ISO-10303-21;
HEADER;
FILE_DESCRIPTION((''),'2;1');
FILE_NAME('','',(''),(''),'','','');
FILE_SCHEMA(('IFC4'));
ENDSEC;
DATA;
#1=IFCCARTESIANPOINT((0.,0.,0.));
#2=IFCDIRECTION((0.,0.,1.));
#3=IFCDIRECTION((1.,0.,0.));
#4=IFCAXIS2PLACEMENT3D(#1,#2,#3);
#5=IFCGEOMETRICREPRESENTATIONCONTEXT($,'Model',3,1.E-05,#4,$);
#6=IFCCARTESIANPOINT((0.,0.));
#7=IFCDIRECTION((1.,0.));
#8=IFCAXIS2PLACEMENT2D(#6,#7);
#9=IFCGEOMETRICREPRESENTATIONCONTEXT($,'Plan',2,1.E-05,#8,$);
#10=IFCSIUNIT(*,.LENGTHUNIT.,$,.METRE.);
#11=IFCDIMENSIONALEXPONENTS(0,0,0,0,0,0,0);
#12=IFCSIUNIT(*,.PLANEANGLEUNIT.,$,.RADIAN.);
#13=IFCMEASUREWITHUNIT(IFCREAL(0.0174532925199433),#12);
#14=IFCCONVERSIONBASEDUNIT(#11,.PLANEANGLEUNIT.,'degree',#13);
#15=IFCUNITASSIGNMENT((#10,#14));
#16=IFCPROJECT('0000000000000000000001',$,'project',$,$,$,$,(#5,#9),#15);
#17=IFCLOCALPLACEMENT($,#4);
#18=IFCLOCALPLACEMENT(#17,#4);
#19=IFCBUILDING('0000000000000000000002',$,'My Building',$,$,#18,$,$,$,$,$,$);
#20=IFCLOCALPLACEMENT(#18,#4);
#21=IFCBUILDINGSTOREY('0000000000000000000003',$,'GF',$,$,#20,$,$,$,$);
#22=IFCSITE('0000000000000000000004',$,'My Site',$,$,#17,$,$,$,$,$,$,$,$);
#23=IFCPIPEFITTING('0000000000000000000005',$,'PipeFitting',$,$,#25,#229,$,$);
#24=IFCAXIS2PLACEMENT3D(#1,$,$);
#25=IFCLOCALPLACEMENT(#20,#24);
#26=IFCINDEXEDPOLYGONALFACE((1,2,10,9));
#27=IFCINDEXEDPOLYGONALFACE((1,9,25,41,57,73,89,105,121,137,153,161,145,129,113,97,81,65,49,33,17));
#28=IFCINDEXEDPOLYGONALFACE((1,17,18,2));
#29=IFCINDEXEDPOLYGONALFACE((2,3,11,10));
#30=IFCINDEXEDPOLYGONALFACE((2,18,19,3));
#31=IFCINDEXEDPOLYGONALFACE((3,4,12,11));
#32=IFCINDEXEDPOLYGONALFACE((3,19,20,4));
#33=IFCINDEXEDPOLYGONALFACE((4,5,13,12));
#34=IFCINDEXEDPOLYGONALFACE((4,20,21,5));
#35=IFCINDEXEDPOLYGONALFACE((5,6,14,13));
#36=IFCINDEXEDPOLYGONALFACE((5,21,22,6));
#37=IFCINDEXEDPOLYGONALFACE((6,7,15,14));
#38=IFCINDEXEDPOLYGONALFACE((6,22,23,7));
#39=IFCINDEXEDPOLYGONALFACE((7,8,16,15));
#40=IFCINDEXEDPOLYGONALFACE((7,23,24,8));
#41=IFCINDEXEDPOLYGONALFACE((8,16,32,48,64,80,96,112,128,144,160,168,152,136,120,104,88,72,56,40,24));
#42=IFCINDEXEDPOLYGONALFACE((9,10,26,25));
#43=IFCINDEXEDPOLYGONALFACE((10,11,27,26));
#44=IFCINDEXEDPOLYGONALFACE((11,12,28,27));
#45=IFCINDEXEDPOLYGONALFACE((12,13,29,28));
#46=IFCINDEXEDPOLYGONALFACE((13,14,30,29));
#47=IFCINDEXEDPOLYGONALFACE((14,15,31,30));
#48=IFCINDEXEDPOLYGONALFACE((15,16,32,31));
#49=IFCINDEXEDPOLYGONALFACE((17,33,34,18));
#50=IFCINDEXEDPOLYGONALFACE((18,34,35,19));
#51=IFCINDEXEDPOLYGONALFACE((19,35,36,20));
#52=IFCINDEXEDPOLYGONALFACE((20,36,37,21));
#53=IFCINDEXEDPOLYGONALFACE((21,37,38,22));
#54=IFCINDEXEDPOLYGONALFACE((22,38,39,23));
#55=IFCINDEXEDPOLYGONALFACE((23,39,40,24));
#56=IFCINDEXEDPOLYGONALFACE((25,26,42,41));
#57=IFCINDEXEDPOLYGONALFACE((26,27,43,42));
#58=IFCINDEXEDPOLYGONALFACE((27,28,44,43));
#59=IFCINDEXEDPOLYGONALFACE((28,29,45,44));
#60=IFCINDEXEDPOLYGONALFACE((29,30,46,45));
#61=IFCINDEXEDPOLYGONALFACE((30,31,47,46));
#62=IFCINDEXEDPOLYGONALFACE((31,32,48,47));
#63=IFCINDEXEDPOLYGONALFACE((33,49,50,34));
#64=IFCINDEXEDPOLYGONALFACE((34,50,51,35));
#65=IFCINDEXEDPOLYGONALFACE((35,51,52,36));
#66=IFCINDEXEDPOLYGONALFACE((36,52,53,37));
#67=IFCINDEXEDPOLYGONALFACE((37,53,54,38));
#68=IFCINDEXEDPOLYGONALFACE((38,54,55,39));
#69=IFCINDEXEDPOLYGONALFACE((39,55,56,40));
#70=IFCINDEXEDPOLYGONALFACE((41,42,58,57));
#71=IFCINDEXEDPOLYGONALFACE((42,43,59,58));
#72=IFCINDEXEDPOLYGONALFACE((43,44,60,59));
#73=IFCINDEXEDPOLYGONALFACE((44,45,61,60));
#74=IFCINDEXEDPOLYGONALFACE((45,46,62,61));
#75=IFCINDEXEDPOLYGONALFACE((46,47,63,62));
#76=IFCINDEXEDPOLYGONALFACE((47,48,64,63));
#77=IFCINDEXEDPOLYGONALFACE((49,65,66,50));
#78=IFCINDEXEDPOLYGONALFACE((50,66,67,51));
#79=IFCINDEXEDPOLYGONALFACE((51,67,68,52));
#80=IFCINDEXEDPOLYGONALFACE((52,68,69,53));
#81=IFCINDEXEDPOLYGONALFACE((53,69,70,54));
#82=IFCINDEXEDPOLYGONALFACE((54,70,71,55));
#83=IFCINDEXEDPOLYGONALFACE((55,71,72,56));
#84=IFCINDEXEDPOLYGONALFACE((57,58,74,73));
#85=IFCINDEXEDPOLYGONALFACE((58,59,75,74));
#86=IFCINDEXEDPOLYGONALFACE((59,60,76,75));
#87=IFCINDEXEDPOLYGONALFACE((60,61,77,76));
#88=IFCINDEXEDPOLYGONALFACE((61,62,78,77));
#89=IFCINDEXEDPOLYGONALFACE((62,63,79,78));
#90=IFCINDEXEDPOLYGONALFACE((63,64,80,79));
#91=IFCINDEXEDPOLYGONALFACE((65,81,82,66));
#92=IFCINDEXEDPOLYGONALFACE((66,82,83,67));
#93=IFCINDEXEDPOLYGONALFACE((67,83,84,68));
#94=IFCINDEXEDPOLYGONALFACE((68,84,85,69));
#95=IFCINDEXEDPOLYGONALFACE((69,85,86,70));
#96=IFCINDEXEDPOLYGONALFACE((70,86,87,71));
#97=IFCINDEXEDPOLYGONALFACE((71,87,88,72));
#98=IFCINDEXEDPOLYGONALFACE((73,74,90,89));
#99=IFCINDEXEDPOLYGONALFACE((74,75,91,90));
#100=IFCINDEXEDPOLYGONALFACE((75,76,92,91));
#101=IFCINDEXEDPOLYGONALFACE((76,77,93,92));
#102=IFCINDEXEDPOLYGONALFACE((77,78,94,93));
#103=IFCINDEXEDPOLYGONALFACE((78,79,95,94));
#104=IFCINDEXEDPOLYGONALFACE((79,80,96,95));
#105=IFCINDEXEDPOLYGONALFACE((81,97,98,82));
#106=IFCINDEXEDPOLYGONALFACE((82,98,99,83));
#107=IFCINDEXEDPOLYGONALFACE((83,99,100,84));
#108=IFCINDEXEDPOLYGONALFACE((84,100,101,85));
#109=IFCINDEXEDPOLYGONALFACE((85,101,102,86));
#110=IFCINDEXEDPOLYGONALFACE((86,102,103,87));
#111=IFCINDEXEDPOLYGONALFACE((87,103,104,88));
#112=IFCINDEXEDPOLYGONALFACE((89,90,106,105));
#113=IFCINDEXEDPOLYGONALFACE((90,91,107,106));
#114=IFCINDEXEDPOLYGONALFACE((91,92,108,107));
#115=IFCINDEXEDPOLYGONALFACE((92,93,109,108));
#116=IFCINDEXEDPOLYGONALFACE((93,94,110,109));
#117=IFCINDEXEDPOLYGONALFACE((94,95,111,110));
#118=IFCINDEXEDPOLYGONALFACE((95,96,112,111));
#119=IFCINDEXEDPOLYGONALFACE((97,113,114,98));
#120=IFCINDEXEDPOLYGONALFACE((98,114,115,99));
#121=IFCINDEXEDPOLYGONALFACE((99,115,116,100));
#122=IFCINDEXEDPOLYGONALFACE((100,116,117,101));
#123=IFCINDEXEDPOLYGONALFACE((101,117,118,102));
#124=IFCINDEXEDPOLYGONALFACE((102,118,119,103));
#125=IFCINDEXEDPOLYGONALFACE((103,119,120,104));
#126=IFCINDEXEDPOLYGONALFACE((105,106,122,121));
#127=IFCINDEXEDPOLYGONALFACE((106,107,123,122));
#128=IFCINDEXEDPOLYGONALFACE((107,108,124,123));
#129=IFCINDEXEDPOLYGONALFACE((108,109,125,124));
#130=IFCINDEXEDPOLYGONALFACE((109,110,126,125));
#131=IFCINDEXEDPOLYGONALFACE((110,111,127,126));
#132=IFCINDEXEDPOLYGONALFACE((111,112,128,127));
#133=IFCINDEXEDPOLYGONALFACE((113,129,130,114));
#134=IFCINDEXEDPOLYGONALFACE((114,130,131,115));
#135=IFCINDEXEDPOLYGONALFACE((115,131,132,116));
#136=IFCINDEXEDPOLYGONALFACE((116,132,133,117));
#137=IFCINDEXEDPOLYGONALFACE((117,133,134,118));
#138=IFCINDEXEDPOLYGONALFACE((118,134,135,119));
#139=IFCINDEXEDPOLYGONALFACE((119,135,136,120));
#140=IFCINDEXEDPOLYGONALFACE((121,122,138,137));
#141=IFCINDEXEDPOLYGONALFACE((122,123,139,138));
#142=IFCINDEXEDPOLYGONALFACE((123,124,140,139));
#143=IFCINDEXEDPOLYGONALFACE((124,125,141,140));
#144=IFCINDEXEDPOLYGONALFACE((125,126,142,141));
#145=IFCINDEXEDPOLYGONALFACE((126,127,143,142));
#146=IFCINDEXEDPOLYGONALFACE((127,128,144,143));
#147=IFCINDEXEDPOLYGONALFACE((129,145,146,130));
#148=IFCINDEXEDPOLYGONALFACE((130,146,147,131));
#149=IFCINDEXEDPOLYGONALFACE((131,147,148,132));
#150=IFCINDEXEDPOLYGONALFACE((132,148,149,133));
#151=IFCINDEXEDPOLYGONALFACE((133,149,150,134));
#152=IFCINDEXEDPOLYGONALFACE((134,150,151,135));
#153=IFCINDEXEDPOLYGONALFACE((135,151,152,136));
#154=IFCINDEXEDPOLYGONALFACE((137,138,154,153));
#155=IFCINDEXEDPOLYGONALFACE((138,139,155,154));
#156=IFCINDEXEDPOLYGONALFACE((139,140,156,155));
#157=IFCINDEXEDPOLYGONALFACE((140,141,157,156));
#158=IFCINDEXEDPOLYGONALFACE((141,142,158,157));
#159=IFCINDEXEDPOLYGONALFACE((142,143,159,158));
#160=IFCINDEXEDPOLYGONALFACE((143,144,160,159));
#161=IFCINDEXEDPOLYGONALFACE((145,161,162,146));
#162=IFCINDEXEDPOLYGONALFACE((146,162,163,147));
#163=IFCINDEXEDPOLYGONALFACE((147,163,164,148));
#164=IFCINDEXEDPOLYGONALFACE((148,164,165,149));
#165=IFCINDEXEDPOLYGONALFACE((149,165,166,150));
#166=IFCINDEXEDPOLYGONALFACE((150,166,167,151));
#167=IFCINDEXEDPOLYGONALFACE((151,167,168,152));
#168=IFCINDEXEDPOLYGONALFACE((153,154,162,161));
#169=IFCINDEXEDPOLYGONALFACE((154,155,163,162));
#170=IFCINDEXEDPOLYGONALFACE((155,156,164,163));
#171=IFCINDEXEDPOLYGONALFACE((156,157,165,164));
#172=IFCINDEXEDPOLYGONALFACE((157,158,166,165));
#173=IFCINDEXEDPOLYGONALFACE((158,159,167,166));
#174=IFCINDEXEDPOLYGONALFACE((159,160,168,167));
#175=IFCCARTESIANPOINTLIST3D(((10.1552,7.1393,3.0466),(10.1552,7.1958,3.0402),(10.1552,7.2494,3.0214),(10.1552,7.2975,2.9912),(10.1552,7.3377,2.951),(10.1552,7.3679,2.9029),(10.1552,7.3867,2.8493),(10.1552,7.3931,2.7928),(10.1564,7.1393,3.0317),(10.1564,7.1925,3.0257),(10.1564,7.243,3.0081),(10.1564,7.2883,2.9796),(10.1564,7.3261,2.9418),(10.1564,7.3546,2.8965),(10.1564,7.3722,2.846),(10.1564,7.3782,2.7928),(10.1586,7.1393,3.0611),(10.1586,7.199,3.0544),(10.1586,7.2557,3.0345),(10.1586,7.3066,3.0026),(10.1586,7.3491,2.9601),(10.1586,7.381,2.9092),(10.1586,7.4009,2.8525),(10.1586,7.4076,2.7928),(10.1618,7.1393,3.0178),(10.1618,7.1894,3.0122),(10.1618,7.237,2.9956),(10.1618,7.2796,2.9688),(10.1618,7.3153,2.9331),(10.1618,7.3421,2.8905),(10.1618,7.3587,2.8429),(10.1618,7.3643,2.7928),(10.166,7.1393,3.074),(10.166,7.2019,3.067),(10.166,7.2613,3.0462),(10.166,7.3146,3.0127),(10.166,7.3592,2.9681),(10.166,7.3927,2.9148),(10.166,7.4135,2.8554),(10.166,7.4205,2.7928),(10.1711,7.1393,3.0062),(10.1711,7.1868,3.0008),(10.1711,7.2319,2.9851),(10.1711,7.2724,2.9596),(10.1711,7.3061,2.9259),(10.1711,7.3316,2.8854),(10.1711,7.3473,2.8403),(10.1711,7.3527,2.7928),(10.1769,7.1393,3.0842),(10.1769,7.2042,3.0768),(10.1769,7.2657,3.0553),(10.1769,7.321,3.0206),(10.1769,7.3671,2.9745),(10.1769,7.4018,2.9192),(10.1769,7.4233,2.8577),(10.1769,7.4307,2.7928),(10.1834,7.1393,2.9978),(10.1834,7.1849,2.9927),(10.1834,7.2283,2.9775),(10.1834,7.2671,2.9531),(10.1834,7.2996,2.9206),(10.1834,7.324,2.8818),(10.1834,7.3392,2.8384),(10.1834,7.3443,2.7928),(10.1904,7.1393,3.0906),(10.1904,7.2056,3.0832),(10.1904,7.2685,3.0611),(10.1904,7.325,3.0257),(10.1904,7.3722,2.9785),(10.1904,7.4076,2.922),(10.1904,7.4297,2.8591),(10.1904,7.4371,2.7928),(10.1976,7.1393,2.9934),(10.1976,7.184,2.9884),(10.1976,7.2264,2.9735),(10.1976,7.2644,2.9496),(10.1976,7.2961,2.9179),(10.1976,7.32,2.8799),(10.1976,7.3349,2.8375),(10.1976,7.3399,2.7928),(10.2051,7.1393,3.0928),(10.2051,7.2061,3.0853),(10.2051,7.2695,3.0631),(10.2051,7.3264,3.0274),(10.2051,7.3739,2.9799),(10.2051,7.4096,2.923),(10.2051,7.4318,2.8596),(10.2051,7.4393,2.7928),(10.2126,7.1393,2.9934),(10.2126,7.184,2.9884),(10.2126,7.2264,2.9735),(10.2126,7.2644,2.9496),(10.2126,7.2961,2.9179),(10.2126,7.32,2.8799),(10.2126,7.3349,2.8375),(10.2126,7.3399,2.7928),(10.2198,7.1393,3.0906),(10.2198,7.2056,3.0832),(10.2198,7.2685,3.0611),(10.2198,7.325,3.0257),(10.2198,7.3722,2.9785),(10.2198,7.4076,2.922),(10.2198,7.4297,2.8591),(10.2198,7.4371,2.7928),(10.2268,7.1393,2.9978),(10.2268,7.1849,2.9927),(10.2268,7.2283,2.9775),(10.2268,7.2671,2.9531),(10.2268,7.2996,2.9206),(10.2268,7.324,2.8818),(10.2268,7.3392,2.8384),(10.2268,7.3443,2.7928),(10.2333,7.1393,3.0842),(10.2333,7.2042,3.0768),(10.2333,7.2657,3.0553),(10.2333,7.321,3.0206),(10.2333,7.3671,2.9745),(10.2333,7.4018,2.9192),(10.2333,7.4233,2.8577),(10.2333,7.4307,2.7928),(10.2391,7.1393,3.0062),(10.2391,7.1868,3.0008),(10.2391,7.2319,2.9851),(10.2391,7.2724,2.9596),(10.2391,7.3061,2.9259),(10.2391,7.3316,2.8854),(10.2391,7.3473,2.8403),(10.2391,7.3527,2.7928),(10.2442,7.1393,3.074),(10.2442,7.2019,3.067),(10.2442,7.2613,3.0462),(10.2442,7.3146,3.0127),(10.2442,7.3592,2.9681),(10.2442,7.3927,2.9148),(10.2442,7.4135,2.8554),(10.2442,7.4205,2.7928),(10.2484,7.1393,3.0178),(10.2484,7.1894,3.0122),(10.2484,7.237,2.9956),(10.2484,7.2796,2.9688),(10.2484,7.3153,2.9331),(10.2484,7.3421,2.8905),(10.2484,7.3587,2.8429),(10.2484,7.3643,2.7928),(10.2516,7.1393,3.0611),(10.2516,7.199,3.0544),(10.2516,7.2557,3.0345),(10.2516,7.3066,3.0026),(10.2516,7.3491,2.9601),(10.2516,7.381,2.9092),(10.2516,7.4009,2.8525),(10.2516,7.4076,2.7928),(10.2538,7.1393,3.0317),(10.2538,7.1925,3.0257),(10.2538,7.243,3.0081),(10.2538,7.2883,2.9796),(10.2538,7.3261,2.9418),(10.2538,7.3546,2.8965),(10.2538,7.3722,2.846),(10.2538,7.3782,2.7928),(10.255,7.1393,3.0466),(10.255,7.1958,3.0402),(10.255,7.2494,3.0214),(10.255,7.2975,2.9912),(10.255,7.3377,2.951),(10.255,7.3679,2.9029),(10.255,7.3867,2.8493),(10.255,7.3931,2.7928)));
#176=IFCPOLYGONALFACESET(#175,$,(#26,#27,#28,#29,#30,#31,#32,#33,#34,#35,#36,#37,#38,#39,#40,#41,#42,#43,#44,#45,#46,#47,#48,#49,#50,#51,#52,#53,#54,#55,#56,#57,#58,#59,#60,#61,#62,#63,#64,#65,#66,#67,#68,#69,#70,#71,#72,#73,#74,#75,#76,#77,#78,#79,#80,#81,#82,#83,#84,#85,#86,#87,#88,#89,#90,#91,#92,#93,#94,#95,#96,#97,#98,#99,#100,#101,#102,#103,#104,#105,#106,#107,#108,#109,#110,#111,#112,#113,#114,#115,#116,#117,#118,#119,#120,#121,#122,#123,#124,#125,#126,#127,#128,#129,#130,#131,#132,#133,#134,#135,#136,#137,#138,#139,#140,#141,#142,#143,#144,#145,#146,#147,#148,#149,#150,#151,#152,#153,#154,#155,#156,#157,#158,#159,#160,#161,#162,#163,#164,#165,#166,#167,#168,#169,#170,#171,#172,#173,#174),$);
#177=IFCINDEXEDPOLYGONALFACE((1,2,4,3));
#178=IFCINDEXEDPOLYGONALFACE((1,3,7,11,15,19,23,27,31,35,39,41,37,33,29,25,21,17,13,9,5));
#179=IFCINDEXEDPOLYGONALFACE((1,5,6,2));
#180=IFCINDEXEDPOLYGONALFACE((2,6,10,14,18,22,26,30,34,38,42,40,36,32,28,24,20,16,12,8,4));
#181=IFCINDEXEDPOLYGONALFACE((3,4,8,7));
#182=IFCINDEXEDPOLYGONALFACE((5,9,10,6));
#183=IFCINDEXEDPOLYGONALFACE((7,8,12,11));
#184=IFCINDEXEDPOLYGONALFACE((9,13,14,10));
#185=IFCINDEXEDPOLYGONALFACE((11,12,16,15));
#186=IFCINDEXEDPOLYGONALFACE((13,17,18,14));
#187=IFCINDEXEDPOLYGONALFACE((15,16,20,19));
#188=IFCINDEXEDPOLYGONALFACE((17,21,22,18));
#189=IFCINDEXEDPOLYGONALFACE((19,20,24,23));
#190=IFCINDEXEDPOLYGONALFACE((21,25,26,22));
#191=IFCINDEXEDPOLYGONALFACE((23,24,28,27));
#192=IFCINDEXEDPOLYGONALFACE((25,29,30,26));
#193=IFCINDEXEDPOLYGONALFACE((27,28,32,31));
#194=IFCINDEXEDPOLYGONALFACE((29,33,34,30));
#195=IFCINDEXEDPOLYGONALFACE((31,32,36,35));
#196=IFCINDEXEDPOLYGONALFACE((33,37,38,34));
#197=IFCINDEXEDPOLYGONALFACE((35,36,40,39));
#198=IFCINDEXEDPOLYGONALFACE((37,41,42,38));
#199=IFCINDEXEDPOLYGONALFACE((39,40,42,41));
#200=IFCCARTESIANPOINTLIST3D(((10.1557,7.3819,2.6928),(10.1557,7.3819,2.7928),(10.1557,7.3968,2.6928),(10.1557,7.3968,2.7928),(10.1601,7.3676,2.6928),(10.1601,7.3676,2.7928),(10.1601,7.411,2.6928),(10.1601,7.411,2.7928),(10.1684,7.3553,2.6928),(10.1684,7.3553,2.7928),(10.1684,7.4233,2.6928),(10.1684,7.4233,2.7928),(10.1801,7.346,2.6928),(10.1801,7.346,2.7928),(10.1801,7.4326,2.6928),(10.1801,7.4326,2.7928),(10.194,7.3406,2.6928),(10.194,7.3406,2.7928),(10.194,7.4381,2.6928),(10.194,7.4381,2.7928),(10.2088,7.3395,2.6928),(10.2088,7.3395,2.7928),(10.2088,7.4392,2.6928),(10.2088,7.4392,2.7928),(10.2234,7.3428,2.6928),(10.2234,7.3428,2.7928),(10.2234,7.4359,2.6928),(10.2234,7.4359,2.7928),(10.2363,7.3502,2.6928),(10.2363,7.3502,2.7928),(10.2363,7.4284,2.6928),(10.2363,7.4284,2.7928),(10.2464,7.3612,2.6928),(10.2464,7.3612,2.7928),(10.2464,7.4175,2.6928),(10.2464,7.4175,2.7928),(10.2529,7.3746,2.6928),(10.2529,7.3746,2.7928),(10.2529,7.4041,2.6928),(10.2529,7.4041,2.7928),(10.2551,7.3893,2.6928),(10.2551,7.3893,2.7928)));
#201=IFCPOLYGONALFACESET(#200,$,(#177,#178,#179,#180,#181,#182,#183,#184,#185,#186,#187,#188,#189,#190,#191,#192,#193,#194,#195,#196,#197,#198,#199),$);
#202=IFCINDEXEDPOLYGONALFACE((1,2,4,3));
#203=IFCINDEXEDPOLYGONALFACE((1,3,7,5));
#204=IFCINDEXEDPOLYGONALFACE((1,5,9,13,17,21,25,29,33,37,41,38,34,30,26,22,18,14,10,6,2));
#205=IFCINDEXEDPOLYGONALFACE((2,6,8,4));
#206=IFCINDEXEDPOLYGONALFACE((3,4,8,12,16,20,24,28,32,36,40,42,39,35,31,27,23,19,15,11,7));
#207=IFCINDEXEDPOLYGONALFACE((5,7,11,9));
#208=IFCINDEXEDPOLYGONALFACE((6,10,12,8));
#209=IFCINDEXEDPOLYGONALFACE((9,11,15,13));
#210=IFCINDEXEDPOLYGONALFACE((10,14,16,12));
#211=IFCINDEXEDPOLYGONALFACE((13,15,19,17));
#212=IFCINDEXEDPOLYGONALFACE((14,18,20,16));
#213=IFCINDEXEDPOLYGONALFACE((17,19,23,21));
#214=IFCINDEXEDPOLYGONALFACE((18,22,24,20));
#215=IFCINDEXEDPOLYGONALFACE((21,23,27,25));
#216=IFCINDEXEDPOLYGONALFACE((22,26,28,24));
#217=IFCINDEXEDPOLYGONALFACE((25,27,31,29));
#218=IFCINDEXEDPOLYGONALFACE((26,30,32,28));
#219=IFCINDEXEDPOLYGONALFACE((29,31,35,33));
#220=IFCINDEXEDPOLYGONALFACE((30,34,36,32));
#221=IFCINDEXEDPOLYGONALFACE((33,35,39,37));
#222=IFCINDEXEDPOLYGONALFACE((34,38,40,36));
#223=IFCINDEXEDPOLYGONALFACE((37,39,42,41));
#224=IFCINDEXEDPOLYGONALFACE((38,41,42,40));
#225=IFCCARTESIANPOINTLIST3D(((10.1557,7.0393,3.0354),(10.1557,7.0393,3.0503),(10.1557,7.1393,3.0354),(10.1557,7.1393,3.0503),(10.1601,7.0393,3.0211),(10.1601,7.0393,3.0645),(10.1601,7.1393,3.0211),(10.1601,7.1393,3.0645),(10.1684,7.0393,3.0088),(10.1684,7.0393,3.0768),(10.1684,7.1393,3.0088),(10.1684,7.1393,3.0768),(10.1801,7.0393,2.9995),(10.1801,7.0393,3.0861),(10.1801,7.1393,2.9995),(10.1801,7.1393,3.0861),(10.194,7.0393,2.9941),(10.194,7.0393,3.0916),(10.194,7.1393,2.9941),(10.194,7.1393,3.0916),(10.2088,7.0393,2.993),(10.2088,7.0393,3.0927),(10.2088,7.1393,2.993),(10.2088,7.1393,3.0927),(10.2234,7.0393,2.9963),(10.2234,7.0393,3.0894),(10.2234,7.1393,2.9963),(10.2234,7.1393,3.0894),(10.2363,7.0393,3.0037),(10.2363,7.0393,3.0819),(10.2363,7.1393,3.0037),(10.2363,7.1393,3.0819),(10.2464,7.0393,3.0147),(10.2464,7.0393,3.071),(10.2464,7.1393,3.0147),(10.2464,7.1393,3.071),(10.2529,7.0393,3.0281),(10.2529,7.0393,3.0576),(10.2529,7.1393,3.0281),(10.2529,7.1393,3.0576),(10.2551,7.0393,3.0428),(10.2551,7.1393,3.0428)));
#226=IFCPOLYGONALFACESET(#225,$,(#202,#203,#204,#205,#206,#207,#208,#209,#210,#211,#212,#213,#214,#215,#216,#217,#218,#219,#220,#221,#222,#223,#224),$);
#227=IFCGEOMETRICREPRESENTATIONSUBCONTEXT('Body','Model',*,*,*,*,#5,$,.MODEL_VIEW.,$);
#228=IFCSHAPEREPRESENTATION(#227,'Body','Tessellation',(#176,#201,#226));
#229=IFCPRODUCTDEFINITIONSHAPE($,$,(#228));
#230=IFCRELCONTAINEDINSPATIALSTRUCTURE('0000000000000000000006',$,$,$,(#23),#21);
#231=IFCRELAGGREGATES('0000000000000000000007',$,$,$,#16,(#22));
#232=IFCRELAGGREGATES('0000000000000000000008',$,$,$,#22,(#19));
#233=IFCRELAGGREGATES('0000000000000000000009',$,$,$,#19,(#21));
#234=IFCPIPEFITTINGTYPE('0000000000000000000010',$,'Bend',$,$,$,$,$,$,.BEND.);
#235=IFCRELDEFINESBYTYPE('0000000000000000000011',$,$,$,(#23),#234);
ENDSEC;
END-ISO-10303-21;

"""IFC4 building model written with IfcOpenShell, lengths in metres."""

from ifc_helpers import new_model, entity, si_unit, converted_unit, frame, origin_with_axes, origin_2d_with_axis, place, context, subcontext, project, spatial, line, indexed_curve, circle, outline, extrude, source, transform, mapped, type_object, type_shapes, element, save


model = new_model("IFC4")

# Units and contexts
model_context = context("Model", 3, precision=1e-05, world=origin_with_axes())
plan_context = context("Plan", 2, precision=1e-05, world=origin_2d_with_axis())
body_context = subcontext(model_context, "Body", "Model", "MODEL_VIEW")
ifc_project = project(units=[si_unit("LENGTHUNIT", "METRE"), converted_unit("PLANEANGLEUNIT", "degree", entity("IfcReal", 0.0174532925199433), si_unit("PLANEANGLEUNIT", "RADIAN"), dimensions=[0, 0, 0, 0, 0, 0, 0])], contexts=[model_context, plan_context])

# Site, building, storey
site_placement = place(None, origin_with_axes())
site = spatial("IfcSite", under=ifc_project, at=site_placement, Name="My Site")
building_placement = place(site_placement, origin_with_axes())
building = spatial("IfcBuilding", under=site, at=building_placement, Name="My Building")
storey_placement = place(building_placement, origin_with_axes())
storey = spatial("IfcBuildingStorey", under=building, at=storey_placement, Name="GF")

# Pipe fitting, opening
pipe_fitting_type = type_object("IfcPipeFittingType", Name="Bend", PredefinedType="BEND")
shared_shape = source(origin_with_axes(), body_context, "Body", "SolidModel", [
    entity("IfcSweptDiskSolid", entity("IfcIndexedPolyCurve", entity("IfcCartesianPointList3D", [[0.0, 0.0, 0.1], [0.0, -0.0732, 0.2768], [0.0, -0.25, 0.35]]), [entity("IfcArcIndex", [1, 2, 3])]), 0.05),
    extrude(circle(Radius=0.05), origin_with_axes(), (0.0, 0.0, 1.0), 0.1),
    extrude(circle(Radius=0.05), frame((0.0, -0.25, 0.35), z_axis=(0.0, -1.0, 0.0), x_axis=(1.0, 0.0, 0.0)), (0.0, 0.0, 1.0), 0.1),
])
type_shapes(pipe_fitting_type, [shared_shape])
pipe_fitting_1_placement = place(storey_placement, frame((10.2051, 7.3893, 2.6928), z_axis=(0.0, 0.0, 1.0), x_axis=(1.0, 0.0, 0.0)))
pipe_fitting_1 = element("IfcPipeFitting", 1, at=pipe_fitting_1_placement, inside=storey, type_object=pipe_fitting_type, Name="PipeFitting", context=body_context, shape_type="MappedRepresentation", body=[
    mapped(shared_shape, transform((0.0, 0.0, 0.0), x_axis=(1.0, 0.0, 0.0), y_axis=(0.0, 1.0, 0.0), z_axis=(0.0, 0.0, 1.0), scale=1.0)),
])
opening_1_placement = place(pipe_fitting_1_placement, frame((-10.2051, -7.3893, -2.6928), z_axis=(0.0, 0.0, 1.0), x_axis=(1.0, 0.0, 0.0)))
element("IfcOpeningElement", 2, at=opening_1_placement, cuts=pipe_fitting_1, PredefinedType="OPENING", context=body_context, shape_type="SweptSolid", body=[
    extrude(outline(indexed_curve([(0.0, 0.0), (0.5, 0.0), (0.5, 0.5), (0.0, 0.5)], segments=[line(1, 2, 3, 4, 1)])), origin_with_axes(), (0.0, 0.0, 1.0), 0.5),
])

save(model, "model.ifc")
